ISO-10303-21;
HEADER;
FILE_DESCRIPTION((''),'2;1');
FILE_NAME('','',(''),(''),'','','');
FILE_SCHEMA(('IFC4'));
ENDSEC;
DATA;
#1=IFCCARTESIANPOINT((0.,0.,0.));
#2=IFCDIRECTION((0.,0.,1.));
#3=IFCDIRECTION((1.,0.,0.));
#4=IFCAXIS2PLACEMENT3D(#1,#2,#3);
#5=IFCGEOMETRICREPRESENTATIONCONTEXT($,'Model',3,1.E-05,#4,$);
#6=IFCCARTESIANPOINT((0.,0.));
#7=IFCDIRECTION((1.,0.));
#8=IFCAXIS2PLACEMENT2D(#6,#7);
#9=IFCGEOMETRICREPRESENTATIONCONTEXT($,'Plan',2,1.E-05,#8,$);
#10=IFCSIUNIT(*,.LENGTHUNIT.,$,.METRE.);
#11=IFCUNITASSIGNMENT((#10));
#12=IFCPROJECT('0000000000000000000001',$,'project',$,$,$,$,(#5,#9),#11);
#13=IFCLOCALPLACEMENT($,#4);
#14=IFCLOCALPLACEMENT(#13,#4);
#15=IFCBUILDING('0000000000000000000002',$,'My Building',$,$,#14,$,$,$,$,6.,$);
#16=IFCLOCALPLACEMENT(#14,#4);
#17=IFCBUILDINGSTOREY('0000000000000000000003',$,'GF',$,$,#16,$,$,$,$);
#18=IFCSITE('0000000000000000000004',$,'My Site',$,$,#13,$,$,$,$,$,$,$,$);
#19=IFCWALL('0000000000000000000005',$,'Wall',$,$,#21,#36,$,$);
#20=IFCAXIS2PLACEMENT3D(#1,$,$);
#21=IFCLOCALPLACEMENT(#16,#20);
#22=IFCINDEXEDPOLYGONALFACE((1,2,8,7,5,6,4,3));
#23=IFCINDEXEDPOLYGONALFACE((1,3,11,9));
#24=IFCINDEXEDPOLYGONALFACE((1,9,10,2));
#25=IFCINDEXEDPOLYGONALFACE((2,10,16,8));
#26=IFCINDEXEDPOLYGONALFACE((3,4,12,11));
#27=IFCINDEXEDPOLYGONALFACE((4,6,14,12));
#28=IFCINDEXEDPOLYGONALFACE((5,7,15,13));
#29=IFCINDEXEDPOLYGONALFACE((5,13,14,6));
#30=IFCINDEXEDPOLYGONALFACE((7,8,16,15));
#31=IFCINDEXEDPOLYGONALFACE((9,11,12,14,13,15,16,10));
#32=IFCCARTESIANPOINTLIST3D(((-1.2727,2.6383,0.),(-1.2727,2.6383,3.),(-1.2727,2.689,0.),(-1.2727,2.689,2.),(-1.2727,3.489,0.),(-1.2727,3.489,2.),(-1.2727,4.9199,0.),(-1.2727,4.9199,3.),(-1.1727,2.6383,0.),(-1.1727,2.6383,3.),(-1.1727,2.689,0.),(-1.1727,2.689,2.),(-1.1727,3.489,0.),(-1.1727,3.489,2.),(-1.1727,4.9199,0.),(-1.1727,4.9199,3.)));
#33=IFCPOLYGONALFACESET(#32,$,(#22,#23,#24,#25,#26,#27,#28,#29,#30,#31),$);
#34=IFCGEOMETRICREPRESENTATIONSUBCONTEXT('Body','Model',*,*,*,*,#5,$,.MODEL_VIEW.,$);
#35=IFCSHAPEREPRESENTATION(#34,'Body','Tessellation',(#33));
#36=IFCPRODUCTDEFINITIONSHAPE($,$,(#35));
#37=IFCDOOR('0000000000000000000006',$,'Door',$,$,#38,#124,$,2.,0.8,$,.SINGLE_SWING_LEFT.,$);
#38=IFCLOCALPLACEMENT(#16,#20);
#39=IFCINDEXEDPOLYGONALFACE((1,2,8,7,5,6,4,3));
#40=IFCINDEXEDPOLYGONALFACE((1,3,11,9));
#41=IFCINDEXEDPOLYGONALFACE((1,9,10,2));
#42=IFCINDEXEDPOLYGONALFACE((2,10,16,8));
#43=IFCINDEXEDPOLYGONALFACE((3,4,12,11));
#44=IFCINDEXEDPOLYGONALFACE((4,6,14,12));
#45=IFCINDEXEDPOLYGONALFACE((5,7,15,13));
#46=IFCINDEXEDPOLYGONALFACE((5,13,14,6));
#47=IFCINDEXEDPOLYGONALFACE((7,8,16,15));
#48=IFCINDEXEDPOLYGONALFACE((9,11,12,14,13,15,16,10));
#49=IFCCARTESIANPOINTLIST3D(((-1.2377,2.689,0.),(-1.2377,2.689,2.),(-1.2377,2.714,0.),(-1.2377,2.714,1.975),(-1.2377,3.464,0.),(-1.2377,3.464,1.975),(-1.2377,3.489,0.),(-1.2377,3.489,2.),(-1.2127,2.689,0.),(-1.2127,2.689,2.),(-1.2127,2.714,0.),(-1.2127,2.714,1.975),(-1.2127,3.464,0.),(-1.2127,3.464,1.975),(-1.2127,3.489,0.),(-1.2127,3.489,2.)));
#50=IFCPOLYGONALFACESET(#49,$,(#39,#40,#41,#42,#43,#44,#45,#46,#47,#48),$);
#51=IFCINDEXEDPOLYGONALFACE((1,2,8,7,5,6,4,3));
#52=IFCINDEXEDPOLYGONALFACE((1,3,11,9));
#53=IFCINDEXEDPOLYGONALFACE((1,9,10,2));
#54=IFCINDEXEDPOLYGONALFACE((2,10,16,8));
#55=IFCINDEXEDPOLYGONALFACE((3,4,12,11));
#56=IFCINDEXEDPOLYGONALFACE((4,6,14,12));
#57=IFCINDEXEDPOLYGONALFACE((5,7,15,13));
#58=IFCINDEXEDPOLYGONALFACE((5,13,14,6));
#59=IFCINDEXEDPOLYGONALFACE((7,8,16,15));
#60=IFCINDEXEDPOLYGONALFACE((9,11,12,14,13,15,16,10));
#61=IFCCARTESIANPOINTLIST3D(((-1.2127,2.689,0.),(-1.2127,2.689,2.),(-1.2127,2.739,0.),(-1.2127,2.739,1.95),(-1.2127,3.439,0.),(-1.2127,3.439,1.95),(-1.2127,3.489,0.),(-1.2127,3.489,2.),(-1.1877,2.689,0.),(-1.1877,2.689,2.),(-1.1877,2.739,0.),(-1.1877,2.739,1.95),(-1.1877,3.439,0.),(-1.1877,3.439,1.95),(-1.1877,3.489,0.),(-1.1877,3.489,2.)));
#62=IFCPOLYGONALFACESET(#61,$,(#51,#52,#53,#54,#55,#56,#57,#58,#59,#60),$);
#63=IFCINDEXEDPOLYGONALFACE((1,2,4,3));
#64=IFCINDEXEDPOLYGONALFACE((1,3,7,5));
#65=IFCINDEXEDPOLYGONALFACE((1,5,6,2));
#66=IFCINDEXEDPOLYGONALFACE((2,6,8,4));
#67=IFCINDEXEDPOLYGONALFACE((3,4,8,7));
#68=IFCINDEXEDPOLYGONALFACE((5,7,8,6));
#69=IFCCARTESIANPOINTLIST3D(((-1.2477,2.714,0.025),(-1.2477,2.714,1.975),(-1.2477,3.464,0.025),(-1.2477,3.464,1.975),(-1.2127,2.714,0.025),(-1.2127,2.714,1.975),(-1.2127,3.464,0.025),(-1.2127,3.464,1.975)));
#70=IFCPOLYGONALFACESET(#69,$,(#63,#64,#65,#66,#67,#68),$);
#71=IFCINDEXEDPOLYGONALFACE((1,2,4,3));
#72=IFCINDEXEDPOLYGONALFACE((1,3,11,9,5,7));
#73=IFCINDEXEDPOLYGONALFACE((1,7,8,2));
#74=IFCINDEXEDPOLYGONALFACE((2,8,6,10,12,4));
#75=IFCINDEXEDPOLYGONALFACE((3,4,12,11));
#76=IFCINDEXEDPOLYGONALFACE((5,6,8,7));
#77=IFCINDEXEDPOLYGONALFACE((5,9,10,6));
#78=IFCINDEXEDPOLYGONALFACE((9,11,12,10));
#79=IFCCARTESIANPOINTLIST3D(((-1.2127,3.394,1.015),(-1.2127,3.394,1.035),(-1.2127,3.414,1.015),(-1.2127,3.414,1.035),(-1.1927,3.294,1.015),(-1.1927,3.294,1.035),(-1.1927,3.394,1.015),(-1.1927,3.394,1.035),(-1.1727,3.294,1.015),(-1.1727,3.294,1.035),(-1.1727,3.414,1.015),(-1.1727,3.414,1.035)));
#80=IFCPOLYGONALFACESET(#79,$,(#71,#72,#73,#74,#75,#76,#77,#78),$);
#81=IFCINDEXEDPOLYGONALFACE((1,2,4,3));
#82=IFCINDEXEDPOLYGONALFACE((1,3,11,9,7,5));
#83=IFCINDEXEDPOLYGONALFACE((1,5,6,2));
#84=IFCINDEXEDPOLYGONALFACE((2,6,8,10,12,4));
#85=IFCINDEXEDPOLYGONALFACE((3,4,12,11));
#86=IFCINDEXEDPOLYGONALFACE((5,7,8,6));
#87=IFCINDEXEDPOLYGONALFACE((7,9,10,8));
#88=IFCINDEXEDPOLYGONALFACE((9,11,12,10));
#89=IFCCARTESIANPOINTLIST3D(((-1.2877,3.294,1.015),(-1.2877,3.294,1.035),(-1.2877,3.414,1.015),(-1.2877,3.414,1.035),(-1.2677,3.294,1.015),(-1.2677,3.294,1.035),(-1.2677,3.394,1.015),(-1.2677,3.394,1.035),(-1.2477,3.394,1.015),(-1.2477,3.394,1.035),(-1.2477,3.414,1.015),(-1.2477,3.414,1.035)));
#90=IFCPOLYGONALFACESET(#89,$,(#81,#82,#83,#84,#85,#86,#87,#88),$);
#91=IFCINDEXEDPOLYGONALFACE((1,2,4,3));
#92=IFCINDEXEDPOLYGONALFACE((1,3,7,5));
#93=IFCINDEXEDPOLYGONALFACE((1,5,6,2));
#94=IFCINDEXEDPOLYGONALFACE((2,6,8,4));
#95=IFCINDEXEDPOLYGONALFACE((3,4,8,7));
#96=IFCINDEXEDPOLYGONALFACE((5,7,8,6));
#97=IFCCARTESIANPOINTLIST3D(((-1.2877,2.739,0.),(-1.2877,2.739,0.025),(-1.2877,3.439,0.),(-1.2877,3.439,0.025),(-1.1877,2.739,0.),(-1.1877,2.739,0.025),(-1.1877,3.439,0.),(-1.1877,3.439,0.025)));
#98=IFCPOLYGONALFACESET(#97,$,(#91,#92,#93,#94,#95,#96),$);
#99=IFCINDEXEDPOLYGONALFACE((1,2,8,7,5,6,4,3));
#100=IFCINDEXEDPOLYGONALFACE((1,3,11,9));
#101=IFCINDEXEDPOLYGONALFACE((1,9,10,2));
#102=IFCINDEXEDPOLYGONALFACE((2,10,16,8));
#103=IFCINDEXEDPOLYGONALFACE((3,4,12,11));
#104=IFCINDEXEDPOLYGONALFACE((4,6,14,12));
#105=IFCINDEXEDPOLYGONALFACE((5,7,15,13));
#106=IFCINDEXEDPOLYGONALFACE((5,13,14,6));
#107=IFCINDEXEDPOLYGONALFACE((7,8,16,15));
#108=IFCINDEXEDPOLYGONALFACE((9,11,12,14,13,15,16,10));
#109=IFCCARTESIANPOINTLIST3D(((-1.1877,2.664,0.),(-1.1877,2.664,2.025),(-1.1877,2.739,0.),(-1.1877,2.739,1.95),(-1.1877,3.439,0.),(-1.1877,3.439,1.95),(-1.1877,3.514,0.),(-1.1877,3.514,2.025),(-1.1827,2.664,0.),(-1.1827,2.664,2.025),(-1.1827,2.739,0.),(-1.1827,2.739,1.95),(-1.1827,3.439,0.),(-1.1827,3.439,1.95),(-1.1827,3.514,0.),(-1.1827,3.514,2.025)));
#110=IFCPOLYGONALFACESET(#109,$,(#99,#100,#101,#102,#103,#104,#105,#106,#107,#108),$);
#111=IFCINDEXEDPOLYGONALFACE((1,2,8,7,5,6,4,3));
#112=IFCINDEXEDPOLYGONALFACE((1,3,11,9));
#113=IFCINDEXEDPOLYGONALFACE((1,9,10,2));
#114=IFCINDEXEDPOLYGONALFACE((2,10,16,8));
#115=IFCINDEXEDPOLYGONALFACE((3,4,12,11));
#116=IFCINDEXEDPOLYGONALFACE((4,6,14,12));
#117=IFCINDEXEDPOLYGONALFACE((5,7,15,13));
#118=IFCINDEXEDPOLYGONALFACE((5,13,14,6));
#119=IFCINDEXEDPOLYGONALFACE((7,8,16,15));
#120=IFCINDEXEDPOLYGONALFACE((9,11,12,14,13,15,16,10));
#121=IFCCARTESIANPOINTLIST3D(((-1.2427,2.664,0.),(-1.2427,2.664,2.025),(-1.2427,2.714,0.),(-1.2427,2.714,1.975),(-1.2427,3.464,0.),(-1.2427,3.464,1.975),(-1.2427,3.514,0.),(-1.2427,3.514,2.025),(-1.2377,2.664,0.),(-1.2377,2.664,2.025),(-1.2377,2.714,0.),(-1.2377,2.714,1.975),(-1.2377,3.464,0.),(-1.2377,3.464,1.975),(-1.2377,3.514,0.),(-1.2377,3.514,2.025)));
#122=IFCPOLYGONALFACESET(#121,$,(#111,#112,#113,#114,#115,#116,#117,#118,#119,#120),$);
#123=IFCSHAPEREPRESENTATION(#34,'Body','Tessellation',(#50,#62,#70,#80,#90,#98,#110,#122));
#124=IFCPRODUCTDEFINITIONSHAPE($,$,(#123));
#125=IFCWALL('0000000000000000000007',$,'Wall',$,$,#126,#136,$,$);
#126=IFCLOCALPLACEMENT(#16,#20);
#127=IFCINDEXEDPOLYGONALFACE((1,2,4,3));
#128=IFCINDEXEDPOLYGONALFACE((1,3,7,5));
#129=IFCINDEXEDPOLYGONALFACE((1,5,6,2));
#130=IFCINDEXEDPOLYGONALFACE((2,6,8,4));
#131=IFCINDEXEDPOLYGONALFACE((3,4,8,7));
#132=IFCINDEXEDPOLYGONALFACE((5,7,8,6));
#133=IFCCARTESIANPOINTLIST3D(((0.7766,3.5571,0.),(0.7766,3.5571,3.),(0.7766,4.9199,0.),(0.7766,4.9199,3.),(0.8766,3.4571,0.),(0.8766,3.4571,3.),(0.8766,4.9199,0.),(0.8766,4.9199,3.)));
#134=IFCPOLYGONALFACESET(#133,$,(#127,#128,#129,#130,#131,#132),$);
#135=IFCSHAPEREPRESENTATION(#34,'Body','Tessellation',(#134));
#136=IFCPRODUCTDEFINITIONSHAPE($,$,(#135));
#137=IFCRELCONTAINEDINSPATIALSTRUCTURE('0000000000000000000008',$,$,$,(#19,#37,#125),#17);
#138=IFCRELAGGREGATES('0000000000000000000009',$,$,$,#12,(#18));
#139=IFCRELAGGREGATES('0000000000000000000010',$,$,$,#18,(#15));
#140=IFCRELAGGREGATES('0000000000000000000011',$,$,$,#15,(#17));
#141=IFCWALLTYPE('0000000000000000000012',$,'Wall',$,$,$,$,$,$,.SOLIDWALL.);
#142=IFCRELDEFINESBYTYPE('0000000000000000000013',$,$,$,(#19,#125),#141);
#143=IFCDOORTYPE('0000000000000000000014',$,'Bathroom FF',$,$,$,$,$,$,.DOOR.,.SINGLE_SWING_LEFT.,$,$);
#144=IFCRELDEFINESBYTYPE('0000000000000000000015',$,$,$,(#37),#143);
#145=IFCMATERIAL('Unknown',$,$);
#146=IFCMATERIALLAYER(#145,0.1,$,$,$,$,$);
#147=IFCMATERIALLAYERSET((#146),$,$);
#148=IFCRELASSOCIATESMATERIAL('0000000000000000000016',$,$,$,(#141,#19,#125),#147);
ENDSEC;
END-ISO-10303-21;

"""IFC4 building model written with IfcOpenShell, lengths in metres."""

from ifc_helpers import new_model, entity, si_unit, frame, origin_with_axes, origin_2d_with_axis, place, context, subcontext, project, spatial, line, indexed_curve, outline, extrude, shape, source, transform, mapped, material, layer, layer_set, layer_usage, type_object, type_shapes, element, fill, save


model = new_model("IFC4")

# Units and contexts
model_context = context("Model", 3, precision=1e-05, world=origin_with_axes())
plan_context = context("Plan", 2, precision=1e-05, world=origin_2d_with_axis())
body_context_1 = subcontext(model_context, "Body", "Model", "MODEL_VIEW")
body_context_2 = subcontext(plan_context, "Body", "Plan", "PLAN_VIEW")
ifc_project = project(units=[si_unit("LENGTHUNIT", "METRE")], contexts=[model_context, plan_context])

# Site, building, storey
site_placement = place(None, origin_with_axes())
site = spatial("IfcSite", under=ifc_project, at=site_placement, Name="My Site")
building_placement = place(site_placement, origin_with_axes())
building = spatial("IfcBuilding", under=site, at=building_placement, Name="My Building", ElevationOfTerrain=6.0)
storey_placement = place(building_placement, origin_with_axes())
storey = spatial("IfcBuildingStorey", under=building, at=storey_placement, Name="GF")

# Shared definitions
ifc_material = material(Name="Unknown")
ifc_layer = layer(ifc_material, 0.1)
ifc_layer_set = layer_set([ifc_layer])
wall_type = type_object("IfcWallType", Name="Wall", PredefinedType="SOLIDWALL", material=ifc_layer_set)

# Wall, opening, door
ifc_layer_usage_1 = layer_usage(ifc_layer_set, "AXIS2", "POSITIVE", 0.0)
wall_1_placement = place(storey_placement, frame((-1.1727, 2.6383, 0.0), z_axis=(0.0, 0.0, 1.0), x_axis=(0.0, 1.0, 0.0)))
wall_1 = element("IfcWall", 1, at=wall_1_placement, inside=storey, type_object=wall_type, material=ifc_layer_usage_1, Name="Wall", context=body_context_1, shape_type="SweptSolid", body=[
    extrude(outline(indexed_curve([(0.0, 0.0), (0.0, 0.1), (2.2816, 0.1), (2.2816, 0.0)], segments=[line(1, 2, 3, 4, 1)])), origin_with_axes(), (0.0, 0.0, 1.0), 3.0),
])
shared_shape_1 = source(origin_with_axes(), body_context_1, "Body", "SweptSolid", [
    extrude(outline(indexed_curve([(0.0, 0.0), (0.8, 0.0), (0.8, 2.0), (0.0, 2.0)], segments=[line(1, 2, 3, 4, 1)])), frame((0.0, -0.6, 0.0), z_axis=(0.0, -1.0, 0.0), x_axis=(1.0, 0.0, 0.0)), (0.0, 0.0, -1.0), 1.2),
])
opening_1_placement = place(wall_1_placement, frame((0.0507, 0.015, 0.0), z_axis=(0.0, 0.0, 1.0), x_axis=(1.0, 0.0, 0.0)))
opening_1 = element("IfcOpeningElement", 2, at=opening_1_placement, cuts=wall_1, PredefinedType="OPENING", context=body_context_1, shape_type="MappedRepresentation", body=[
    mapped(shared_shape_1, transform((0.0, 0.0, 0.0), x_axis=(1.0, 0.0, 0.0), y_axis=(0.0, 1.0, 0.0), z_axis=(0.0, 0.0, 1.0), scale=1.0)),
])
door_type_1 = type_object("IfcDoorType", Name="Bathroom FF", OperationType="SINGLE_SWING_LEFT", PredefinedType="DOOR")
shared_shape_2 = source(origin_with_axes(), body_context_1, "Body", "SweptSolid", [
    extrude(outline(indexed_curve([(0.0, 0.0), (0.0, 2.0), (0.8, 2.0), (0.8, 0.0), (0.775, 0.0), (0.775, 1.975), (0.025, 1.975), (0.025, 0.0)], segments=[line(1, 2, 3, 4, 5, 6, 7, 8, 1)])), frame((0.0, 0.025, 0.0), z_axis=(0.0, -1.0, 0.0), x_axis=(1.0, 0.0, 0.0)), (0.0, 0.0, -1.0), 0.025),
    extrude(outline(indexed_curve([(0.0, 0.0), (0.0, 2.0), (0.8, 2.0), (0.8, 0.0), (0.75, 0.0), (0.75, 1.95), (0.05, 1.95), (0.05, 0.0)], segments=[line(1, 2, 3, 4, 5, 6, 7, 8, 1)])), frame((0.0, 0.0, 0.0), z_axis=(0.0, -1.0, 0.0), x_axis=(1.0, 0.0, 0.0)), (0.0, 0.0, -1.0), 0.025),
    extrude(outline(indexed_curve([(0.0, 0.0), (0.75, 0.0), (0.75, 0.035), (0.0, 0.035)], segments=[line(1, 2, 3, 4, 1)])), frame((0.025, 0.025, 0.025), z_axis=(0.0, 0.0, 1.0), x_axis=(1.0, 0.0, 0.0)), (0.0, 0.0, 1.0), 1.95),
    extrude(outline(indexed_curve([(0.0, 0.0), (0.0, -0.04), (-0.12, -0.04), (-0.12, -0.02), (-0.02, -0.02), (-0.02, 0.0)], segments=[line(1, 2, 3, 4, 5, 6, 1)])), frame((0.725, 0.025, 1.015), z_axis=(0.0, 0.0, 1.0), x_axis=(1.0, 0.0, 0.0)), (0.0, 0.0, 1.0), 0.02),
    extrude(outline(indexed_curve([(0.0, 0.0), (0.0, 0.04), (-0.12, 0.04), (-0.12, 0.02), (-0.02, 0.02), (-0.02, 0.0)], segments=[line(1, 2, 3, 4, 5, 6, 1)])), frame((0.725, 0.06, 1.015), z_axis=(0.0, 0.0, 1.0), x_axis=(1.0, 0.0, 0.0)), (0.0, 0.0, 1.0), 0.02),
    extrude(outline(indexed_curve([(0.0, 0.0), (0.7, 0.0), (0.7, 0.1), (0.0, 0.1)], segments=[line(1, 2, 3, 4, 1)])), frame((0.05, 0.0, 0.0), z_axis=(0.0, 0.0, 1.0), x_axis=(1.0, 0.0, 0.0)), (0.0, 0.0, 1.0), 0.025),
    extrude(outline(indexed_curve([(0.0, 0.0), (0.0, 2.025), (0.85, 2.025), (0.85, 0.0), (0.775, 0.0), (0.775, 1.95), (0.075, 1.95), (0.075, 0.0)], segments=[line(1, 2, 3, 4, 5, 6, 7, 8, 1)])), frame((-0.025, -0.005, 0.0), z_axis=(0.0, -1.0, 0.0), x_axis=(1.0, 0.0, 0.0)), (0.0, 0.0, -1.0), 0.005),
    extrude(outline(indexed_curve([(0.0, 0.0), (0.0, 2.025), (0.85, 2.025), (0.85, 0.0), (0.8, 0.0), (0.8, 1.975), (0.05, 1.975), (0.05, 0.0)], segments=[line(1, 2, 3, 4, 5, 6, 7, 8, 1)])), frame((-0.025, 0.05, 0.0), z_axis=(0.0, -1.0, 0.0), x_axis=(1.0, 0.0, 0.0)), (0.0, 0.0, -1.0), 0.005),
])
shared_shape_3 = source(origin_with_axes(), body_context_2, "Body", "Curve2D", [
    entity("IfcIndexedPolyCurve", entity("IfcCartesianPointList2D", [[0.0, 0.0], [0.0, 0.05], [0.025, 0.05], [0.025, 0.025], [0.05, 0.025], [0.05, 0.0]]), [entity("IfcLineIndex", [1, 2, 3, 4, 5, 6, 1])]),
    entity("IfcIndexedPolyCurve", entity("IfcCartesianPointList2D", [[0.8, 0.0], [0.8, 0.05], [0.775, 0.05], [0.775, 0.025], [0.75, 0.025], [0.75, 0.0]]), [entity("IfcLineIndex", [1, 2, 3, 4, 5, 6, 1])]),
    entity("IfcTrimmedCurve", entity("IfcEllipse", entity("IfcAxis2Placement2D", entity("IfcCartesianPoint", [0.06, 0.05]), entity("IfcDirection", [1.0, 0.0])), 0.715, 0.75), [entity("IfcCartesianPoint", [0.775, 0.05])], [entity("IfcCartesianPoint", [0.06, 0.8])], True, "CARTESIAN"),
    entity("IfcIndexedPolyCurve", entity("IfcCartesianPointList2D", [[0.025, 0.05], [0.06, 0.05], [0.06, 0.8], [0.025, 0.8]]), [entity("IfcLineIndex", [1, 2, 3, 4, 1])]),
])
type_shapes(door_type_1, [shared_shape_2, shared_shape_3])
door_1_placement = place(opening_1_placement, frame((0.0, 0.0, 0.0), z_axis=(0.0, 0.0, 1.0), x_axis=(1.0, 0.0, 0.0)))
door_1 = element("IfcDoor", 3, at=door_1_placement, inside=storey, type_object=door_type_1, Name="Door", OperationType="SINGLE_SWING_LEFT", OverallHeight=2.0, OverallWidth=0.8, shapes=[
    shape(body_context_1, "Body", "MappedRepresentation", [mapped(shared_shape_2, transform((0.0, 0.0, 0.0), x_axis=(1.0, 0.0, 0.0), y_axis=(0.0, 1.0, 0.0), z_axis=(0.0, 0.0, 1.0), scale=1.0))]),
    shape(body_context_2, "Body", "MappedRepresentation", [mapped(shared_shape_3, transform((0.0, 0.0, 0.0), x_axis=(1.0, 0.0, 0.0), y_axis=(0.0, 1.0, 0.0), z_axis=(0.0, 0.0, 1.0), scale=1.0))]),
])
fill(opening_1, door_1)

# Wall
ifc_layer_usage_2 = layer_usage(ifc_layer_set, "AXIS2", "POSITIVE", 0.0)
wall_2_placement = place(storey_placement, frame((0.7766, 5.0199, 0.0), z_axis=(0.0, 0.0, 1.0), x_axis=(0.0, -1.0, 0.0)))
element("IfcWall", 4, at=wall_2_placement, inside=storey, type_object=wall_type, material=ifc_layer_usage_2, Name="Wall", context=body_context_1, shape_type="SweptSolid", body=[
    extrude(outline(indexed_curve([(0.1, 0.0), (0.1, 0.1), (1.5628, 0.1), (1.4628, 0.0)], segments=[line(1, 2, 3, 4, 1)])), origin_with_axes(), (0.0, 0.0, 1.0), 3.0),
])

save(model, "model.ifc")
